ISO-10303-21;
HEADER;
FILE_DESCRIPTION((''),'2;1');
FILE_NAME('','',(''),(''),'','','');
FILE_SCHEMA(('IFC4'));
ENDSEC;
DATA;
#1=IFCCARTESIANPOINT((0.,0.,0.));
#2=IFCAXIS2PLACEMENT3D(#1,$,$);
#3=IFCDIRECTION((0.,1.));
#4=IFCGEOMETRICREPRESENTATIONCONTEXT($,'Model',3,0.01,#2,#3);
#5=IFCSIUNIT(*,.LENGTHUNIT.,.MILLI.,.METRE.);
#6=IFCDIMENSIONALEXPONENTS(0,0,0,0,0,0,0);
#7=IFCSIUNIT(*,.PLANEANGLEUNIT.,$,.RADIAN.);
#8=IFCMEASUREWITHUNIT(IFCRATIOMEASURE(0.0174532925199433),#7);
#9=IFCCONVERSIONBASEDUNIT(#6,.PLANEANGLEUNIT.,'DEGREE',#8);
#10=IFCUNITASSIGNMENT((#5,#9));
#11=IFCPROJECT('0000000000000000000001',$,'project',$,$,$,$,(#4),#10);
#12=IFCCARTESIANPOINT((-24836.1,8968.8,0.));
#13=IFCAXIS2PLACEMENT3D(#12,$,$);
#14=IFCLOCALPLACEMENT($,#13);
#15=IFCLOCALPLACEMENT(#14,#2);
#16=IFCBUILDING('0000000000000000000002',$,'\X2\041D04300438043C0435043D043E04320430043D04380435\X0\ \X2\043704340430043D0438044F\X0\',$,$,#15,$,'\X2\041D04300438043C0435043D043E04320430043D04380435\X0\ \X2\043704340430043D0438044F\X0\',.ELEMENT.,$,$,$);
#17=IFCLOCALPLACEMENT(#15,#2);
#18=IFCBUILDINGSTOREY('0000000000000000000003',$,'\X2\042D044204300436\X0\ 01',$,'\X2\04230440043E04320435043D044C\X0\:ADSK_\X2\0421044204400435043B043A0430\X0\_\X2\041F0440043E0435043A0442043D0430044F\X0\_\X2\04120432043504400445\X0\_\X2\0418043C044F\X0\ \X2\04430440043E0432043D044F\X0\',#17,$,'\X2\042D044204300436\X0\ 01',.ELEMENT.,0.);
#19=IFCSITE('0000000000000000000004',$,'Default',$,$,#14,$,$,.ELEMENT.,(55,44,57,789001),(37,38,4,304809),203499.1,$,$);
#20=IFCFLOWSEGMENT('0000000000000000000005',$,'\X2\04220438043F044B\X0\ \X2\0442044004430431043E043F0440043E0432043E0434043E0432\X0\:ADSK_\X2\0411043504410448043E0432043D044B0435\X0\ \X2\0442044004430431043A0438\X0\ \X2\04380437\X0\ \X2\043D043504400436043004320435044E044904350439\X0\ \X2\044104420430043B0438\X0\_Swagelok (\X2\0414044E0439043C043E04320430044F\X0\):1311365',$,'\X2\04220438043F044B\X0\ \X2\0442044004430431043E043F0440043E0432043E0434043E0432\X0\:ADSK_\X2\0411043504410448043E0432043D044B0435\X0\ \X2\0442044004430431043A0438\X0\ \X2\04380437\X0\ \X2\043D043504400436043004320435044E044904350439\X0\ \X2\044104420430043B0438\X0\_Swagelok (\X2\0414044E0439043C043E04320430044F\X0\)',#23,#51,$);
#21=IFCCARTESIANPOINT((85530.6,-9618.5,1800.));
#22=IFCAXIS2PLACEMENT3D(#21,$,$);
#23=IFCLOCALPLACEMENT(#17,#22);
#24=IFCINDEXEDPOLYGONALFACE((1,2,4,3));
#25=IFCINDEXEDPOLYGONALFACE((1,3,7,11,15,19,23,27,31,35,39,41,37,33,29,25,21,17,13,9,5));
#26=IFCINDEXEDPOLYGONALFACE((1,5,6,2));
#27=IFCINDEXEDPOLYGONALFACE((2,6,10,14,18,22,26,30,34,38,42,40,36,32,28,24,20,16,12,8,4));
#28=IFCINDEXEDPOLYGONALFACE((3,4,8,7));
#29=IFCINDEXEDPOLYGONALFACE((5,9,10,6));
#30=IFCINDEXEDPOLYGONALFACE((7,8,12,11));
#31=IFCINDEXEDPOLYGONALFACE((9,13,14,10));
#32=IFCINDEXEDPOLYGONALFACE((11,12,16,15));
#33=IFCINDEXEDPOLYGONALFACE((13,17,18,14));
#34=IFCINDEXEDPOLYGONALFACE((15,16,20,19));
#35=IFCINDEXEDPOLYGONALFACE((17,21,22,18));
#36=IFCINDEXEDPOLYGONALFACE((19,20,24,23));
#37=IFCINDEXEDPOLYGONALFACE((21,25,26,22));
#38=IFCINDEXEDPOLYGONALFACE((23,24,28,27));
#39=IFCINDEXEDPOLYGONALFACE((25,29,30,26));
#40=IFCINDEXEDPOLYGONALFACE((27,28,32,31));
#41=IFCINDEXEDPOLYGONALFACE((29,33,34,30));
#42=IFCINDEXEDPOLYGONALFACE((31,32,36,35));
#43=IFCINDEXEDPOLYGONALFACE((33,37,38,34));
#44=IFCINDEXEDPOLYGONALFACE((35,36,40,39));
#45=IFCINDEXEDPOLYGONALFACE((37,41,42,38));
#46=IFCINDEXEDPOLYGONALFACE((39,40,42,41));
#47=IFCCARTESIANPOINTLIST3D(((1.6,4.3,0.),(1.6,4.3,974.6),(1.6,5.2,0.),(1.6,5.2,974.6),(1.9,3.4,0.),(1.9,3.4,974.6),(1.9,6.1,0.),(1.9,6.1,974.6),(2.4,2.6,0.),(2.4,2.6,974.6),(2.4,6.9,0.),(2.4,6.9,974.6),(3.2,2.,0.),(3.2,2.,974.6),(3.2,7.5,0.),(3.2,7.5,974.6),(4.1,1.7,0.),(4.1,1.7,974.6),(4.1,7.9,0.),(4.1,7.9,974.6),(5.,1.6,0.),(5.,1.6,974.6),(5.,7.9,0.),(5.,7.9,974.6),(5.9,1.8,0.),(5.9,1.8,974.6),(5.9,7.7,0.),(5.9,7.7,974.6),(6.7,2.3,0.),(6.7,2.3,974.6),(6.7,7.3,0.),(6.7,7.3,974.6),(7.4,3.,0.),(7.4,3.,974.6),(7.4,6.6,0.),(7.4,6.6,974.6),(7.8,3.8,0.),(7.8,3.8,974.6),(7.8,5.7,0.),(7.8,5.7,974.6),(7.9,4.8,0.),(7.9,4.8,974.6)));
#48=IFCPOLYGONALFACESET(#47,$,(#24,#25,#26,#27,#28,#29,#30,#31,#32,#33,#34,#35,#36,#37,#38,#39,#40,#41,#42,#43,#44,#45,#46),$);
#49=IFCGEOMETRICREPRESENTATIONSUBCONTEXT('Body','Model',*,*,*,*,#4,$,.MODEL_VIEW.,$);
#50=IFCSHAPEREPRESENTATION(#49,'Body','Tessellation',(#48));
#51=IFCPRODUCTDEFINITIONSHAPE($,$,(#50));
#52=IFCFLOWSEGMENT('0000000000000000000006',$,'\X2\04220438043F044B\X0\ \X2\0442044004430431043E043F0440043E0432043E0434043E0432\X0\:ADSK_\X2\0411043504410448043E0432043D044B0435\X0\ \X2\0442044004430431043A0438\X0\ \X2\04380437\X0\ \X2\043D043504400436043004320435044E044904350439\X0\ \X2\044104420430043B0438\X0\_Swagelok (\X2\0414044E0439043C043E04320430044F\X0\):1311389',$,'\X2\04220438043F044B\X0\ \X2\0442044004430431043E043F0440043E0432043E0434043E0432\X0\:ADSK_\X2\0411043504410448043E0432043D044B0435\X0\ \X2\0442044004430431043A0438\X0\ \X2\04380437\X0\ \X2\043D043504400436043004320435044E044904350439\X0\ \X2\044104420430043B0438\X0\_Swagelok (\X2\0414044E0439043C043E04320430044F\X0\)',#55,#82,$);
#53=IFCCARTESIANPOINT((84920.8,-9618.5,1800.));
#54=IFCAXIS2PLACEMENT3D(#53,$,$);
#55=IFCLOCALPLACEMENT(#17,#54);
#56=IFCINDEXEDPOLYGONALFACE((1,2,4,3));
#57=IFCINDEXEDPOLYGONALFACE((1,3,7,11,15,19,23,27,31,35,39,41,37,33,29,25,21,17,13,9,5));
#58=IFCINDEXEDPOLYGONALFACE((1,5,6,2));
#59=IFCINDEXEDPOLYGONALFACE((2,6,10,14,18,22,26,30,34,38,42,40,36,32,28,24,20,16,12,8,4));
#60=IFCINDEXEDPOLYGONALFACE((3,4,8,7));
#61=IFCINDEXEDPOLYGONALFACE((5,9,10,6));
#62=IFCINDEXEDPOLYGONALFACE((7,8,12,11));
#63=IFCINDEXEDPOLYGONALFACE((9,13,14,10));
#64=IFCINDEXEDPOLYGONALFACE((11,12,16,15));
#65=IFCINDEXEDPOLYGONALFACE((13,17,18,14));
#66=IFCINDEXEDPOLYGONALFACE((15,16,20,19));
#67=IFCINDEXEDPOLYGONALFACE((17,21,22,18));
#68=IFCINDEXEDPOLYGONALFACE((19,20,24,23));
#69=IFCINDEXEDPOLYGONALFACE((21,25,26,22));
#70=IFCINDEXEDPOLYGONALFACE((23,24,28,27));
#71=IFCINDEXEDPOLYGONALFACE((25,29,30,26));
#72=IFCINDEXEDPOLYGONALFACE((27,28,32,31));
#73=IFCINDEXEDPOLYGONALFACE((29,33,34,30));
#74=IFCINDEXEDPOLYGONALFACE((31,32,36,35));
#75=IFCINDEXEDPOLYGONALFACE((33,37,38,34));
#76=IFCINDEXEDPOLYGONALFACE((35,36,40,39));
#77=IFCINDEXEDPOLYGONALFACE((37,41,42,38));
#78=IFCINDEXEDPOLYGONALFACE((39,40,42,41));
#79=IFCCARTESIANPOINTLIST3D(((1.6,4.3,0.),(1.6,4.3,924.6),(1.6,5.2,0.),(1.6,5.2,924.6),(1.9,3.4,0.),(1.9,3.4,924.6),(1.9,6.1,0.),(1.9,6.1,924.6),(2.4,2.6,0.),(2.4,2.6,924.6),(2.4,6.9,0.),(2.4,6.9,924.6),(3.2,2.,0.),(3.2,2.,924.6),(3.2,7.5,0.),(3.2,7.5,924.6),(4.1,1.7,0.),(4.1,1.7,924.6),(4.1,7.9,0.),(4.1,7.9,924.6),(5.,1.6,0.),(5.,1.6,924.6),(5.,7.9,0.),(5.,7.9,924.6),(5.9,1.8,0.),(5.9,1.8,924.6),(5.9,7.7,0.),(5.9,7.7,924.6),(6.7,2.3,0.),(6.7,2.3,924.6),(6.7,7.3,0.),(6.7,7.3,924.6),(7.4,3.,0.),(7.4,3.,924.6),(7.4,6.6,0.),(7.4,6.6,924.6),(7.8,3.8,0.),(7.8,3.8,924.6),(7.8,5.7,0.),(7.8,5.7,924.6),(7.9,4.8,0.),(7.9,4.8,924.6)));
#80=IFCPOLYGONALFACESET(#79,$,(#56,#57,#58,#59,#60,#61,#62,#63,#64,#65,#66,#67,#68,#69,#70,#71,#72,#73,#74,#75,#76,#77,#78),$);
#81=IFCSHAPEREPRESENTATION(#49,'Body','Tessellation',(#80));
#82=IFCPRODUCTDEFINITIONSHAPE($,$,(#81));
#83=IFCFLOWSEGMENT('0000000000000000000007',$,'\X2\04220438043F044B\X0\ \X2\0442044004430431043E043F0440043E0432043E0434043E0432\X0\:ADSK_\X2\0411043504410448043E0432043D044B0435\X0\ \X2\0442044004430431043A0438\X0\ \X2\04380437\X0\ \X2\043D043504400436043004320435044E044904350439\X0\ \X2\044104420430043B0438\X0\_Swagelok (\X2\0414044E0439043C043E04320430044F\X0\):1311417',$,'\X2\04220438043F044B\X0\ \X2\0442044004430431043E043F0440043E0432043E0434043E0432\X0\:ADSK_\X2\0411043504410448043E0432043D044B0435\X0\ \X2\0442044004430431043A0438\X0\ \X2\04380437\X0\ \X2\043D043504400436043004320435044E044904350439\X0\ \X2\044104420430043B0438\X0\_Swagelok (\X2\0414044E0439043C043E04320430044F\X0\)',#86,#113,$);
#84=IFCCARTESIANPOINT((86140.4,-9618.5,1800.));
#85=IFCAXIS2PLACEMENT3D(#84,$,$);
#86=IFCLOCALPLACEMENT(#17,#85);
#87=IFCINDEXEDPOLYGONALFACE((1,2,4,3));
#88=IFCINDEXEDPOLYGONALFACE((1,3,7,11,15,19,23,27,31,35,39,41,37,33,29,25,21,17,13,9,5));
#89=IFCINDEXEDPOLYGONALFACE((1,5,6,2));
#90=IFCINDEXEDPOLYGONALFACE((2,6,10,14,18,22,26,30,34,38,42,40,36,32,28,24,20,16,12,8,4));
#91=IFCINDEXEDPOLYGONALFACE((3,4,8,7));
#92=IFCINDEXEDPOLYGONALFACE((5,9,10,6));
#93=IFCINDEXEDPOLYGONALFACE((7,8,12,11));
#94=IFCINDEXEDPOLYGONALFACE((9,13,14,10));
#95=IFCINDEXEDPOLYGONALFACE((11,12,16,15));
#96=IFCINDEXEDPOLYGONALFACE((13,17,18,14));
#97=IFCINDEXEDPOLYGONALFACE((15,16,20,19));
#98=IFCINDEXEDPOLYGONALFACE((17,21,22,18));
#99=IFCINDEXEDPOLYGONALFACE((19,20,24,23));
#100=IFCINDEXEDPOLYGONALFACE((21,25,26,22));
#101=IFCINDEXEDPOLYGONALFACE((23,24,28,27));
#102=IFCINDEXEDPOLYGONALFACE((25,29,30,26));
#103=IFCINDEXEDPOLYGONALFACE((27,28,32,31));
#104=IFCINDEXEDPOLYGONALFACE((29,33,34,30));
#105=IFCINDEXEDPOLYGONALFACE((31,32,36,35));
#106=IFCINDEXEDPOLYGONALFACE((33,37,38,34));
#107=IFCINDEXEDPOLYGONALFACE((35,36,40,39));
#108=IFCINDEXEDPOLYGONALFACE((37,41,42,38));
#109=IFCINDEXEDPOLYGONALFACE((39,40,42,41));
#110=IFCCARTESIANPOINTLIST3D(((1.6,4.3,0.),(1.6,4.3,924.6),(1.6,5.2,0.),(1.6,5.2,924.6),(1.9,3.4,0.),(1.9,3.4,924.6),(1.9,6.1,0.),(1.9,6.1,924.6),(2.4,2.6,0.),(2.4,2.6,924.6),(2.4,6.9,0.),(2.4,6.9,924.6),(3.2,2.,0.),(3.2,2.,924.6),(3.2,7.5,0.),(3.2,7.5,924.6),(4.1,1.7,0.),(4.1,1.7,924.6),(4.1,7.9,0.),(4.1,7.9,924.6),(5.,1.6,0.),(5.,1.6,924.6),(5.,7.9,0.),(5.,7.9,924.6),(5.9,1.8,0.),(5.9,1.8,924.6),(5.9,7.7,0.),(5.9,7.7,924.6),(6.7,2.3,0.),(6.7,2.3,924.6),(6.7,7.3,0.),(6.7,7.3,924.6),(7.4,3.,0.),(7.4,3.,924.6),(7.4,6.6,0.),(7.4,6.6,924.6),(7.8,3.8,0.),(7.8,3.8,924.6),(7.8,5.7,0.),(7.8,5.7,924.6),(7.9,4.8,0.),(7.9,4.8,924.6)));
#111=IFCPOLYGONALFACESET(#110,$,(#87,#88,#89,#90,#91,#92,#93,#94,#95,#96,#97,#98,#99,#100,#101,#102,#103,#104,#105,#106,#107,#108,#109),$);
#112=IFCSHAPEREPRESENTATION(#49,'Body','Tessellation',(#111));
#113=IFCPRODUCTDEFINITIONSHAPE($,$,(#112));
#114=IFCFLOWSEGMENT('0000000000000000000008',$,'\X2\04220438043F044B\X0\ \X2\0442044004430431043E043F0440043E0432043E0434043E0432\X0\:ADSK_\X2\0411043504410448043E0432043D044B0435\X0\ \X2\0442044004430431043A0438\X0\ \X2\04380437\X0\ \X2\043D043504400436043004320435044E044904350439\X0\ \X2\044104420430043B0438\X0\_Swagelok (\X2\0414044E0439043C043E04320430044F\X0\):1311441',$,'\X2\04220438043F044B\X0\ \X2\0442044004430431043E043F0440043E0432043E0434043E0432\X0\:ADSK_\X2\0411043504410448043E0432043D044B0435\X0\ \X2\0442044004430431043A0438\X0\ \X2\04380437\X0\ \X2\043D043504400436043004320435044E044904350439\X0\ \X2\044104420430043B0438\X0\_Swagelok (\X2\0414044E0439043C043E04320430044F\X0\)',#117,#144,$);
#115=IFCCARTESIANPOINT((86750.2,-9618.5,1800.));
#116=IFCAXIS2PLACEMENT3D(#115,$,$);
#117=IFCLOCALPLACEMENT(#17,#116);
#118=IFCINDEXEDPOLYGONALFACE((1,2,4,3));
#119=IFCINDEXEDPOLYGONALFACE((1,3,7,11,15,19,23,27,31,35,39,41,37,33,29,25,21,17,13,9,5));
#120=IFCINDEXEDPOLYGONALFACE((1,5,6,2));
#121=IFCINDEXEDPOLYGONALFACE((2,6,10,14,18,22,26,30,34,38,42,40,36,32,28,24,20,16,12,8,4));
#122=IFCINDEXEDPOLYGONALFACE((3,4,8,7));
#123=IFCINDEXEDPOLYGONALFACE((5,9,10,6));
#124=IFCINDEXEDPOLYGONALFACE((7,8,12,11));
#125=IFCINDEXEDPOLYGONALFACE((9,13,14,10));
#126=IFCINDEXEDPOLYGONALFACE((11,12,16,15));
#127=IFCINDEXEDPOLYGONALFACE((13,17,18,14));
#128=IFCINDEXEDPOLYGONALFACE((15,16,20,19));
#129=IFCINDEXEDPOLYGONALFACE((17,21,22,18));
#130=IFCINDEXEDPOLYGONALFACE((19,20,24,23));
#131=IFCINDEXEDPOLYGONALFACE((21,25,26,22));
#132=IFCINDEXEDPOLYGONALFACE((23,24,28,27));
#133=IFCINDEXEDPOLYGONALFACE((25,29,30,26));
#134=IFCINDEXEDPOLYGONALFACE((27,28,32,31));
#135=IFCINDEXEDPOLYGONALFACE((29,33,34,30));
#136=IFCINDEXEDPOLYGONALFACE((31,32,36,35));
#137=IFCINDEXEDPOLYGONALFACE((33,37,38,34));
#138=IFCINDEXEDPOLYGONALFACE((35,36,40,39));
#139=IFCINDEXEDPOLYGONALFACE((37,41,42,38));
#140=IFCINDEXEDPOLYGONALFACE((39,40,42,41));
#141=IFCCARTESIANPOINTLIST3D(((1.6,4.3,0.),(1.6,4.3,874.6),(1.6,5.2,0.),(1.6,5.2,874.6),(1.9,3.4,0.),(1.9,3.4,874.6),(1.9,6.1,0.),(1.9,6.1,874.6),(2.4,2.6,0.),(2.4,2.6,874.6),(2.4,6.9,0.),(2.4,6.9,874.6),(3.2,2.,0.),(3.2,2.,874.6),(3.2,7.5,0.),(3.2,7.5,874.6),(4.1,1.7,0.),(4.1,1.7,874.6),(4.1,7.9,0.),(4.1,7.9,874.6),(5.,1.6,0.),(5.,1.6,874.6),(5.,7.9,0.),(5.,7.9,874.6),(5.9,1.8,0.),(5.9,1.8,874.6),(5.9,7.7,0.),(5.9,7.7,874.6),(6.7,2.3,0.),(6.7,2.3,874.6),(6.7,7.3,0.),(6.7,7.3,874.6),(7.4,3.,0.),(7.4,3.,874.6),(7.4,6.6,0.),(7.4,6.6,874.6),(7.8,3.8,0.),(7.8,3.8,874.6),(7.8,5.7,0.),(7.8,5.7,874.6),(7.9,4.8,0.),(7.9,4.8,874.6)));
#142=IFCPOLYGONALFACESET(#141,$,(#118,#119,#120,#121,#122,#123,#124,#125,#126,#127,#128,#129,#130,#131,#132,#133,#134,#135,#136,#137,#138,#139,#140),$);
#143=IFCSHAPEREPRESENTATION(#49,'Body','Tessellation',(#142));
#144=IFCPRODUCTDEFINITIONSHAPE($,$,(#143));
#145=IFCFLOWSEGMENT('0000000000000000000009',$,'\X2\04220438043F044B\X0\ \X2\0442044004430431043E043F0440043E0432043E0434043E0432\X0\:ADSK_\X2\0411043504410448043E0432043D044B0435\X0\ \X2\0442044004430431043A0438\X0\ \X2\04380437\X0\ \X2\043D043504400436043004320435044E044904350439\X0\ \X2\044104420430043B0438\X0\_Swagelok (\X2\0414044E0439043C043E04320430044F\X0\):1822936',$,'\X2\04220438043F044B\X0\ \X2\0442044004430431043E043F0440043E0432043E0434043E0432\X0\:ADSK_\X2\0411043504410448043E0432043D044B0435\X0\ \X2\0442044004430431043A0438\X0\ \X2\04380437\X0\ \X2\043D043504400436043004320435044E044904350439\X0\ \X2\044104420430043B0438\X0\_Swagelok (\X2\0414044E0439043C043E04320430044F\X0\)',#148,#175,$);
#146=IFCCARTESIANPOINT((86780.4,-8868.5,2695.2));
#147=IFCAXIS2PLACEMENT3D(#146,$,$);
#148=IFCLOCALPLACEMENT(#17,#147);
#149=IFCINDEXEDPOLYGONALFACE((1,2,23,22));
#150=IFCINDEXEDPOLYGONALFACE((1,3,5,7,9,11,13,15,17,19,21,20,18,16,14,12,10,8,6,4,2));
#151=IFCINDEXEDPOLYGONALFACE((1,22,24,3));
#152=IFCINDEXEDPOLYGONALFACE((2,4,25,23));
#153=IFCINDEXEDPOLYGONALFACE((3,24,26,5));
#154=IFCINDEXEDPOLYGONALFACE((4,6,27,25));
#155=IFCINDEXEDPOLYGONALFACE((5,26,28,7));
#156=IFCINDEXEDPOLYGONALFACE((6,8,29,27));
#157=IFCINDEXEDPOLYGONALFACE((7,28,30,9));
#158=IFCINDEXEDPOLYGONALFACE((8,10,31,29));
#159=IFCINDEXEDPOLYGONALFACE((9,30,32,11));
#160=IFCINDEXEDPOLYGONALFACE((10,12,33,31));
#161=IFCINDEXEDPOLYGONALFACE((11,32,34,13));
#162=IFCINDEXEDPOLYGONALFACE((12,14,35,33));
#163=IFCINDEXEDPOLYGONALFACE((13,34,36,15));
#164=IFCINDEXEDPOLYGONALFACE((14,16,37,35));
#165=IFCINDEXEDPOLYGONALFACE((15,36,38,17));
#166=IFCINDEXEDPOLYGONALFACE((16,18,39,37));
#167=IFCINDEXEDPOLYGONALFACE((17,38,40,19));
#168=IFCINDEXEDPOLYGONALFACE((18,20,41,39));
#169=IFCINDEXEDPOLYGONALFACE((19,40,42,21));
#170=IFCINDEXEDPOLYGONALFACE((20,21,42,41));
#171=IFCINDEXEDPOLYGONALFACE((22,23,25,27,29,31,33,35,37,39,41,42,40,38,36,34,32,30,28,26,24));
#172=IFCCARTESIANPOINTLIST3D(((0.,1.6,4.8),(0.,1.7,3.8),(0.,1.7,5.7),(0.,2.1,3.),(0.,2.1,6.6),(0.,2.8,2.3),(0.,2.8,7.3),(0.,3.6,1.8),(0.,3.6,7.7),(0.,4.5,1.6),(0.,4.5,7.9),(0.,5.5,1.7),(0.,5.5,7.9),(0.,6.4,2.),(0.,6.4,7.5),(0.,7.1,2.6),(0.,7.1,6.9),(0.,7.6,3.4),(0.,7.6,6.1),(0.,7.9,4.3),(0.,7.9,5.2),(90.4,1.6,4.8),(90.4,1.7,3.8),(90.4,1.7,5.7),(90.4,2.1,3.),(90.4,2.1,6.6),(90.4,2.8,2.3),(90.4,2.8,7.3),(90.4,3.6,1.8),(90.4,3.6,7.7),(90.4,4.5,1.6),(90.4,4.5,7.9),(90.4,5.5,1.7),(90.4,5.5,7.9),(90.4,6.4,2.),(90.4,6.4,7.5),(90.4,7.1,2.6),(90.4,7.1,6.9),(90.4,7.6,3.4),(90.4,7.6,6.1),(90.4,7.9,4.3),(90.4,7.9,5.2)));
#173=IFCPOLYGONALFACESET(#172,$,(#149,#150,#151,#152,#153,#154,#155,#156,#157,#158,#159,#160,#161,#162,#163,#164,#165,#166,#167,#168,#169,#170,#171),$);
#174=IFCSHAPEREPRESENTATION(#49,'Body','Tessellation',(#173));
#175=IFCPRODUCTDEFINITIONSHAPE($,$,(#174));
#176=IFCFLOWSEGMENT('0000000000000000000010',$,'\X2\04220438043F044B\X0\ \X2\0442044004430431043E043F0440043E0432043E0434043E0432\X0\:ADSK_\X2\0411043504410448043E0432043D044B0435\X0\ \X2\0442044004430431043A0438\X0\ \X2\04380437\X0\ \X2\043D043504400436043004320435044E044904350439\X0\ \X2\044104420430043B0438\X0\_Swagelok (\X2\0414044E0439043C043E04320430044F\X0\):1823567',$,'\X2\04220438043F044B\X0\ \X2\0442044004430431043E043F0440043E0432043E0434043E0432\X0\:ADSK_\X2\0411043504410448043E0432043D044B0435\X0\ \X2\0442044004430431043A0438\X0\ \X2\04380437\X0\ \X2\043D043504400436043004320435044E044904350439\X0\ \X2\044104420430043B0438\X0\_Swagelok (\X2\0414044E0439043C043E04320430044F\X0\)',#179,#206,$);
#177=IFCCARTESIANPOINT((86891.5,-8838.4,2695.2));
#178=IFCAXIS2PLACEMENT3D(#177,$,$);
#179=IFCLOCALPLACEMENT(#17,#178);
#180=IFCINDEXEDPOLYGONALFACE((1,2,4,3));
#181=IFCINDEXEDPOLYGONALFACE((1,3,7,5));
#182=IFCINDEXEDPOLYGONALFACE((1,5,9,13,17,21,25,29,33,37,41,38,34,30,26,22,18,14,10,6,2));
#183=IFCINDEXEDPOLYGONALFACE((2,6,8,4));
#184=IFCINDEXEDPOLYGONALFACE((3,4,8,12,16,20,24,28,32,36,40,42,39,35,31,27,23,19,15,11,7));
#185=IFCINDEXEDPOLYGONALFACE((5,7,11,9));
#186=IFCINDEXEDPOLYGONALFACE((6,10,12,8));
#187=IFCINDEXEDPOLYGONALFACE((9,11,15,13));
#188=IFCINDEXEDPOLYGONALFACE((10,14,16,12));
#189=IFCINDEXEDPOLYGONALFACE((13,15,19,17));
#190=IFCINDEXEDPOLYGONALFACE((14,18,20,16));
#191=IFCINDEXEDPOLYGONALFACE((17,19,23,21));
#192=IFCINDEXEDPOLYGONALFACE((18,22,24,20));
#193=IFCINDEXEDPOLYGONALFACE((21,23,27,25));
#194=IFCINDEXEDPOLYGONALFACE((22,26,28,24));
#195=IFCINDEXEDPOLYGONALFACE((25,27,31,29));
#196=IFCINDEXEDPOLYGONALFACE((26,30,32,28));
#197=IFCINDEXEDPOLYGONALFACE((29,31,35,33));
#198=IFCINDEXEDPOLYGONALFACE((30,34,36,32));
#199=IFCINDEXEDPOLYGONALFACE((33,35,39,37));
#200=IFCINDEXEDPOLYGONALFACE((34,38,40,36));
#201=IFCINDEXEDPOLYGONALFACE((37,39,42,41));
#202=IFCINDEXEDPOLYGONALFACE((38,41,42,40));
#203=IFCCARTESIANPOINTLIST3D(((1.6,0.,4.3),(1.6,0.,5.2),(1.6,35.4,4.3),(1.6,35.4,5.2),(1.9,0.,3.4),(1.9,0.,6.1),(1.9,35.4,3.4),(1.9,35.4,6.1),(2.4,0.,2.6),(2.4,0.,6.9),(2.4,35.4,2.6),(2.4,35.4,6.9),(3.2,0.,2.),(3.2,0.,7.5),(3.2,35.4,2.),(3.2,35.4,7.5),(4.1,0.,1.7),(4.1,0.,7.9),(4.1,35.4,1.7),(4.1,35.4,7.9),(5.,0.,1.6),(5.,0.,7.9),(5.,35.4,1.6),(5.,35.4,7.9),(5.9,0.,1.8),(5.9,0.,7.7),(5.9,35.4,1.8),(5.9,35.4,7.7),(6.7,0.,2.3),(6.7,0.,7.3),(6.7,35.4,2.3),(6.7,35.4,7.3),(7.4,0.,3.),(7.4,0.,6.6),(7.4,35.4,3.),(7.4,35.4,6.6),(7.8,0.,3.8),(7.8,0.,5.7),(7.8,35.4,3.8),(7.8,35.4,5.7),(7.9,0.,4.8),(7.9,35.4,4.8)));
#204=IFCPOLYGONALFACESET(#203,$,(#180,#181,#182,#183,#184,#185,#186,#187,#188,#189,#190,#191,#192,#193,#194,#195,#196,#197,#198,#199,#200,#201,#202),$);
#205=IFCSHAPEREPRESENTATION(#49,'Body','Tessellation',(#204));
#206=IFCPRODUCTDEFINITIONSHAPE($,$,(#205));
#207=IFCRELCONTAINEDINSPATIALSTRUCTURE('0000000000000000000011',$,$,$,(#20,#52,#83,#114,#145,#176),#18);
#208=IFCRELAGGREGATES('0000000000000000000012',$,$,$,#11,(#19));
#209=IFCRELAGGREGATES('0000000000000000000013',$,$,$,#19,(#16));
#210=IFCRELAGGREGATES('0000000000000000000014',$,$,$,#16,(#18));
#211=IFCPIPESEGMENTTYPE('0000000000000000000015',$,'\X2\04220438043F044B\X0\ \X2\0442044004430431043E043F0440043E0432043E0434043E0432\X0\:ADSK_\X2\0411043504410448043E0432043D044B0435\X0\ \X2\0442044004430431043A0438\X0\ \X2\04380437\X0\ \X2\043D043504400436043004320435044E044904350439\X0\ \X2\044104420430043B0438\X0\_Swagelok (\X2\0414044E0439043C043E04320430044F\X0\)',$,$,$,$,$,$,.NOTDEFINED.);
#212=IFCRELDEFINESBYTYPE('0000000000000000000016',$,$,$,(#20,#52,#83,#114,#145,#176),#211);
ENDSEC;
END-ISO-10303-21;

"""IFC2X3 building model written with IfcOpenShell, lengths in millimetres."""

from ifc_helpers import new_model, entity, si_unit, converted_unit, direction, frame, origin, origin_2d_with_axis, place, context, subcontext, project, spatial, circle, extrude, type_object, element, save


model = new_model("IFC2X3")

# Units and contexts
model_context = context("Model", 3, precision=0.01, world=origin(), true_north=direction((0.0, 1.0)))
body_context = subcontext(model_context, "Body", "Model", "MODEL_VIEW")
ifc_project = project(units=[si_unit("LENGTHUNIT", "METRE", prefix="MILLI"), converted_unit("PLANEANGLEUNIT", "DEGREE", entity("IfcRatioMeasure", 0.0174532925199433), si_unit("PLANEANGLEUNIT", "RADIAN"), dimensions=[0, 0, 0, 0, 0, 0, 0])], contexts=[model_context])

# Site, building, storey
site_placement = place(None, frame((-24836.1, 8968.8, 0.0)))
site = spatial("IfcSite", under=ifc_project, at=site_placement, Name="Default", CompositionType="ELEMENT", RefLatitude=(55, 44, 57, 789001), RefLongitude=(37, 38, 4, 304809), RefElevation=203499.1)
building_placement = place(site_placement, origin())
building = spatial("IfcBuilding", under=site, at=building_placement, Name="Наименование здания", LongName="Наименование здания", CompositionType="ELEMENT")
storey_placement = place(building_placement, origin())
storey = spatial("IfcBuildingStorey", under=building, at=storey_placement, Name="Этаж 01", ObjectType="Уровень:ADSK_Стрелка_Проектная_Вверх_Имя уровня", LongName="Этаж 01", CompositionType="ELEMENT", Elevation=0.0)

# Flow segments
pipe_segment_type_1 = type_object("IfcPipeSegmentType", Name="Типы трубопроводов:ADSK_Бесшовные трубки из нержавеющей стали_Swagelok (Дюймовая)", PredefinedType="NOTDEFINED")
flow_segment_1_placement = place(storey_placement, frame((85530.6, -9618.5, 1800.0)))
element("IfcFlowSegment", 1, at=flow_segment_1_placement, inside=storey, type_object=pipe_segment_type_1, Name="Типы трубопроводов:ADSK_Бесшовные трубки из нержавеющей стали_Swagelok (Дюймовая):1311365", ObjectType="Типы трубопроводов:ADSK_Бесшовные трубки из нержавеющей стали_Swagelok (Дюймовая)", context=body_context, shape_type="SweptSolid", body=[
    extrude(circle(Radius=3.2, at=origin_2d_with_axis()), frame((4.8, 4.8, 0.0)), (0.0, 0.0, 1.0), 974.6),
])
flow_segment_2_placement = place(storey_placement, frame((84920.8, -9618.5, 1800.0)))
element("IfcFlowSegment", 2, at=flow_segment_2_placement, inside=storey, type_object=pipe_segment_type_1, Name="Типы трубопроводов:ADSK_Бесшовные трубки из нержавеющей стали_Swagelok (Дюймовая):1311389", ObjectType="Типы трубопроводов:ADSK_Бесшовные трубки из нержавеющей стали_Swagelok (Дюймовая)", context=body_context, shape_type="SweptSolid", body=[
    extrude(circle(Radius=3.2, at=origin_2d_with_axis()), frame((4.8, 4.8, 0.0)), (0.0, 0.0, 1.0), 924.6),
])
flow_segment_3_placement = place(storey_placement, frame((86140.4, -9618.5, 1800.0)))
element("IfcFlowSegment", 3, at=flow_segment_3_placement, inside=storey, type_object=pipe_segment_type_1, Name="Типы трубопроводов:ADSK_Бесшовные трубки из нержавеющей стали_Swagelok (Дюймовая):1311417", ObjectType="Типы трубопроводов:ADSK_Бесшовные трубки из нержавеющей стали_Swagelok (Дюймовая)", context=body_context, shape_type="SweptSolid", body=[
    extrude(circle(Radius=3.2, at=origin_2d_with_axis()), frame((4.8, 4.8, 0.0)), (0.0, 0.0, 1.0), 924.6),
])
flow_segment_4_placement = place(storey_placement, frame((86750.2, -9618.5, 1800.0)))
element("IfcFlowSegment", 4, at=flow_segment_4_placement, inside=storey, type_object=pipe_segment_type_1, Name="Типы трубопроводов:ADSK_Бесшовные трубки из нержавеющей стали_Swagelok (Дюймовая):1311441", ObjectType="Типы трубопроводов:ADSK_Бесшовные трубки из нержавеющей стали_Swagelok (Дюймовая)", context=body_context, shape_type="SweptSolid", body=[
    extrude(circle(Radius=3.2, at=origin_2d_with_axis()), frame((4.8, 4.8, 0.0)), (0.0, 0.0, 1.0), 874.6),
])
flow_segment_5_placement = place(storey_placement, frame((86780.4, -8868.5, 2695.2)))
element("IfcFlowSegment", 5, at=flow_segment_5_placement, inside=storey, type_object=pipe_segment_type_1, Name="Типы трубопроводов:ADSK_Бесшовные трубки из нержавеющей стали_Swagelok (Дюймовая):1822936", ObjectType="Типы трубопроводов:ADSK_Бесшовные трубки из нержавеющей стали_Swagelok (Дюймовая)", context=body_context, shape_type="SweptSolid", body=[
    extrude(circle(Radius=3.2, at=origin_2d_with_axis()), frame((0.0, 4.8, 4.8), z_axis=(1.0, 0.0, 0.0), x_axis=(0.0, -1.0, 0.0)), (0.0, 0.0, 1.0), 90.4),
])
flow_segment_6_placement = place(storey_placement, frame((86891.5, -8838.4, 2695.2)))
element("IfcFlowSegment", 6, at=flow_segment_6_placement, inside=storey, type_object=pipe_segment_type_1, Name="Типы трубопроводов:ADSK_Бесшовные трубки из нержавеющей стали_Swagelok (Дюймовая):1823567", ObjectType="Типы трубопроводов:ADSK_Бесшовные трубки из нержавеющей стали_Swagelok (Дюймовая)", context=body_context, shape_type="SweptSolid", body=[
    extrude(circle(Radius=3.2, at=origin_2d_with_axis()), frame((4.8, 0.0, 4.8), z_axis=(0.0, 1.0, 0.0), x_axis=(1.0, 0.0, 0.0)), (0.0, 0.0, 1.0), 35.4),
])

save(model, "model.ifc")
